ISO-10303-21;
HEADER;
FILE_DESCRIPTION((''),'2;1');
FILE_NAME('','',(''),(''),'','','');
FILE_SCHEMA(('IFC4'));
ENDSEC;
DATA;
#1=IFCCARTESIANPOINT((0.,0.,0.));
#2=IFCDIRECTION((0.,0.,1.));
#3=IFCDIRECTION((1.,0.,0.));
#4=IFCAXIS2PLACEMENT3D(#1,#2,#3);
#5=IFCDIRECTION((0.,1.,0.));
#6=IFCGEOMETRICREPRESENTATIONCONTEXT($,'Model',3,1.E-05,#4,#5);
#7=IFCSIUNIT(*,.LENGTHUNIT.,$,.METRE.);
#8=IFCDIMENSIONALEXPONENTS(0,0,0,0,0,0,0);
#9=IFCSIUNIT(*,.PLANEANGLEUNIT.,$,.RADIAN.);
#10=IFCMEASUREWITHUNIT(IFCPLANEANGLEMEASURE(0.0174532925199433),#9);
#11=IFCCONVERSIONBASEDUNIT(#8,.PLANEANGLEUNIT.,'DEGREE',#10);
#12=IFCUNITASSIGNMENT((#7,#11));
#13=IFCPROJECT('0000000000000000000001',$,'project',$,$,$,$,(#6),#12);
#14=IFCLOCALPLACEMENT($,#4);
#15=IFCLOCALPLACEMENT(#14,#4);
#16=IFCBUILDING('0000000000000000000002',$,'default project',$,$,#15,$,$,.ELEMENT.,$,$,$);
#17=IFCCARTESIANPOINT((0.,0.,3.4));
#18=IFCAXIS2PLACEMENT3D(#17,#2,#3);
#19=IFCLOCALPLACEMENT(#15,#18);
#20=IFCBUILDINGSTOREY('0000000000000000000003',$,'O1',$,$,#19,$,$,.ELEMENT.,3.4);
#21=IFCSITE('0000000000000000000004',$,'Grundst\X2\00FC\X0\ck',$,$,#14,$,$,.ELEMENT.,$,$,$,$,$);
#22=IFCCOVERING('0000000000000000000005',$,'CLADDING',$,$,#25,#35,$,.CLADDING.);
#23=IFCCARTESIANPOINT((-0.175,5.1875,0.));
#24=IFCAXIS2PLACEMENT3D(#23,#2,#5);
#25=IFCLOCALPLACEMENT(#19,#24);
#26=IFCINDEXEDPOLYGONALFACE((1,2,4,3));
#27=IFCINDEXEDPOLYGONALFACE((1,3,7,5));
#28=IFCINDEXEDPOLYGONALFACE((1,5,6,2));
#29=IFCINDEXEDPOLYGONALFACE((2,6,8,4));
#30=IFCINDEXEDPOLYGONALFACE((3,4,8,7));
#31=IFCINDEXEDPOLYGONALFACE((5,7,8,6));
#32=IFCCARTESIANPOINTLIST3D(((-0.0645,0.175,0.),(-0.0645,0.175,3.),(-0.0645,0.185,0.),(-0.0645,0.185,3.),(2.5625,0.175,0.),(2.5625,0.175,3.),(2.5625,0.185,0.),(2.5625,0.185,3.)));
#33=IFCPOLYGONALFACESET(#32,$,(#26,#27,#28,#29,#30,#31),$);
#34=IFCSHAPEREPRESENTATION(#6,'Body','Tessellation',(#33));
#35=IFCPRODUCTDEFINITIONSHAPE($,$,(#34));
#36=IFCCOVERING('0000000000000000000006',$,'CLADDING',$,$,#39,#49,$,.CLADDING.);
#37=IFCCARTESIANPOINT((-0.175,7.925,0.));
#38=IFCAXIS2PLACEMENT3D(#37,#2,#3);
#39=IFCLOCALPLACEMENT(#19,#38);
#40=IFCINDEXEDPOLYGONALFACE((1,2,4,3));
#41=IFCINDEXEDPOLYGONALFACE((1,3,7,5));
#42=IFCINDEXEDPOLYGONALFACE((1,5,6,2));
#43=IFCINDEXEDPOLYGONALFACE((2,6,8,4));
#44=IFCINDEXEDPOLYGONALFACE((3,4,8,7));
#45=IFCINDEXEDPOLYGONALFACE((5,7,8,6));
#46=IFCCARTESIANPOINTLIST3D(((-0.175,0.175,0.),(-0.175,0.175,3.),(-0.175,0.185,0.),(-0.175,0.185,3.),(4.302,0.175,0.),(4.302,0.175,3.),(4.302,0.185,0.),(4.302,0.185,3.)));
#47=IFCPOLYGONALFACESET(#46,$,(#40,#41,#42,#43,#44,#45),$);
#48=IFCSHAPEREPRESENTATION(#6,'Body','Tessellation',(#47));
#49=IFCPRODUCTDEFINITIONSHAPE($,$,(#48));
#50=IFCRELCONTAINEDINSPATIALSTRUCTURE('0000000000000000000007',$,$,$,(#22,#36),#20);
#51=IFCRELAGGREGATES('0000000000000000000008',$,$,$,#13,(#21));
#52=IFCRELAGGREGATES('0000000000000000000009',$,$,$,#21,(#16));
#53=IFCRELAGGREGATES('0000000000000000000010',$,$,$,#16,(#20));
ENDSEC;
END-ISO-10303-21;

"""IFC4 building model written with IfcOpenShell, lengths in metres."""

from ifc_helpers import new_model, entity, si_unit, converted_unit, direction, frame, origin_with_axes, place, context, project, spatial, polyline, outline, extrude, element, save


model = new_model("IFC4")

# Units and contexts
model_context = context("Model", 3, precision=1e-05, world=origin_with_axes(), true_north=direction((0.0, 1.0, 0.0)))
ifc_project = project(units=[si_unit("LENGTHUNIT", "METRE"), converted_unit("PLANEANGLEUNIT", "DEGREE", entity("IfcPlaneAngleMeasure", 0.0174532925199433), si_unit("PLANEANGLEUNIT", "RADIAN"), dimensions=[0, 0, 0, 0, 0, 0, 0])], contexts=[model_context])

# Site, building, storey
site_placement = place(None, origin_with_axes())
site = spatial("IfcSite", under=ifc_project, at=site_placement, Name="Grundstück", CompositionType="ELEMENT")
building_placement = place(site_placement, origin_with_axes())
building = spatial("IfcBuilding", under=site, at=building_placement, Name="default project", CompositionType="ELEMENT")
placement_1 = place(building_placement, frame((0.0, 0.0, 3.4), z_axis=(0.0, 0.0, 1.0), x_axis=(1.0, 0.0, 0.0)))
storey = spatial("IfcBuildingStorey", under=building, at=placement_1, Name="O1", CompositionType="ELEMENT", Elevation=3.4)

# Shared definitions
placement_2 = place(placement_1, frame((-0.175, 5.1875, 0.0), z_axis=(0.0, 0.0, 1.0), x_axis=(0.0, 1.0, 0.0)))
placement_3 = place(placement_1, frame((-0.175, 7.925, 0.0), z_axis=(0.0, 0.0, 1.0), x_axis=(1.0, 0.0, 0.0)))

# Coverings
element("IfcCovering", 1, at=placement_2, inside=storey, Name="CLADDING", PredefinedType="CLADDING", context=model_context, shape_type="SweptSolid", body=[
    extrude(outline(polyline([(2.5625, 0.185), (-0.0645, 0.185), (-0.0645, 0.175), (2.5625, 0.175), (2.5625, 0.185)])), origin_with_axes(), (0.0, 0.0, 1.0), 3.0),
])
element("IfcCovering", 2, at=placement_3, inside=storey, Name="CLADDING", PredefinedType="CLADDING", context=model_context, shape_type="SweptSolid", body=[
    extrude(outline(polyline([(4.302, 0.185), (-0.175, 0.185), (-0.175, 0.175), (4.302, 0.175), (4.302, 0.185)])), origin_with_axes(), (0.0, 0.0, 1.0), 3.0),
])

save(model, "model.ifc")
